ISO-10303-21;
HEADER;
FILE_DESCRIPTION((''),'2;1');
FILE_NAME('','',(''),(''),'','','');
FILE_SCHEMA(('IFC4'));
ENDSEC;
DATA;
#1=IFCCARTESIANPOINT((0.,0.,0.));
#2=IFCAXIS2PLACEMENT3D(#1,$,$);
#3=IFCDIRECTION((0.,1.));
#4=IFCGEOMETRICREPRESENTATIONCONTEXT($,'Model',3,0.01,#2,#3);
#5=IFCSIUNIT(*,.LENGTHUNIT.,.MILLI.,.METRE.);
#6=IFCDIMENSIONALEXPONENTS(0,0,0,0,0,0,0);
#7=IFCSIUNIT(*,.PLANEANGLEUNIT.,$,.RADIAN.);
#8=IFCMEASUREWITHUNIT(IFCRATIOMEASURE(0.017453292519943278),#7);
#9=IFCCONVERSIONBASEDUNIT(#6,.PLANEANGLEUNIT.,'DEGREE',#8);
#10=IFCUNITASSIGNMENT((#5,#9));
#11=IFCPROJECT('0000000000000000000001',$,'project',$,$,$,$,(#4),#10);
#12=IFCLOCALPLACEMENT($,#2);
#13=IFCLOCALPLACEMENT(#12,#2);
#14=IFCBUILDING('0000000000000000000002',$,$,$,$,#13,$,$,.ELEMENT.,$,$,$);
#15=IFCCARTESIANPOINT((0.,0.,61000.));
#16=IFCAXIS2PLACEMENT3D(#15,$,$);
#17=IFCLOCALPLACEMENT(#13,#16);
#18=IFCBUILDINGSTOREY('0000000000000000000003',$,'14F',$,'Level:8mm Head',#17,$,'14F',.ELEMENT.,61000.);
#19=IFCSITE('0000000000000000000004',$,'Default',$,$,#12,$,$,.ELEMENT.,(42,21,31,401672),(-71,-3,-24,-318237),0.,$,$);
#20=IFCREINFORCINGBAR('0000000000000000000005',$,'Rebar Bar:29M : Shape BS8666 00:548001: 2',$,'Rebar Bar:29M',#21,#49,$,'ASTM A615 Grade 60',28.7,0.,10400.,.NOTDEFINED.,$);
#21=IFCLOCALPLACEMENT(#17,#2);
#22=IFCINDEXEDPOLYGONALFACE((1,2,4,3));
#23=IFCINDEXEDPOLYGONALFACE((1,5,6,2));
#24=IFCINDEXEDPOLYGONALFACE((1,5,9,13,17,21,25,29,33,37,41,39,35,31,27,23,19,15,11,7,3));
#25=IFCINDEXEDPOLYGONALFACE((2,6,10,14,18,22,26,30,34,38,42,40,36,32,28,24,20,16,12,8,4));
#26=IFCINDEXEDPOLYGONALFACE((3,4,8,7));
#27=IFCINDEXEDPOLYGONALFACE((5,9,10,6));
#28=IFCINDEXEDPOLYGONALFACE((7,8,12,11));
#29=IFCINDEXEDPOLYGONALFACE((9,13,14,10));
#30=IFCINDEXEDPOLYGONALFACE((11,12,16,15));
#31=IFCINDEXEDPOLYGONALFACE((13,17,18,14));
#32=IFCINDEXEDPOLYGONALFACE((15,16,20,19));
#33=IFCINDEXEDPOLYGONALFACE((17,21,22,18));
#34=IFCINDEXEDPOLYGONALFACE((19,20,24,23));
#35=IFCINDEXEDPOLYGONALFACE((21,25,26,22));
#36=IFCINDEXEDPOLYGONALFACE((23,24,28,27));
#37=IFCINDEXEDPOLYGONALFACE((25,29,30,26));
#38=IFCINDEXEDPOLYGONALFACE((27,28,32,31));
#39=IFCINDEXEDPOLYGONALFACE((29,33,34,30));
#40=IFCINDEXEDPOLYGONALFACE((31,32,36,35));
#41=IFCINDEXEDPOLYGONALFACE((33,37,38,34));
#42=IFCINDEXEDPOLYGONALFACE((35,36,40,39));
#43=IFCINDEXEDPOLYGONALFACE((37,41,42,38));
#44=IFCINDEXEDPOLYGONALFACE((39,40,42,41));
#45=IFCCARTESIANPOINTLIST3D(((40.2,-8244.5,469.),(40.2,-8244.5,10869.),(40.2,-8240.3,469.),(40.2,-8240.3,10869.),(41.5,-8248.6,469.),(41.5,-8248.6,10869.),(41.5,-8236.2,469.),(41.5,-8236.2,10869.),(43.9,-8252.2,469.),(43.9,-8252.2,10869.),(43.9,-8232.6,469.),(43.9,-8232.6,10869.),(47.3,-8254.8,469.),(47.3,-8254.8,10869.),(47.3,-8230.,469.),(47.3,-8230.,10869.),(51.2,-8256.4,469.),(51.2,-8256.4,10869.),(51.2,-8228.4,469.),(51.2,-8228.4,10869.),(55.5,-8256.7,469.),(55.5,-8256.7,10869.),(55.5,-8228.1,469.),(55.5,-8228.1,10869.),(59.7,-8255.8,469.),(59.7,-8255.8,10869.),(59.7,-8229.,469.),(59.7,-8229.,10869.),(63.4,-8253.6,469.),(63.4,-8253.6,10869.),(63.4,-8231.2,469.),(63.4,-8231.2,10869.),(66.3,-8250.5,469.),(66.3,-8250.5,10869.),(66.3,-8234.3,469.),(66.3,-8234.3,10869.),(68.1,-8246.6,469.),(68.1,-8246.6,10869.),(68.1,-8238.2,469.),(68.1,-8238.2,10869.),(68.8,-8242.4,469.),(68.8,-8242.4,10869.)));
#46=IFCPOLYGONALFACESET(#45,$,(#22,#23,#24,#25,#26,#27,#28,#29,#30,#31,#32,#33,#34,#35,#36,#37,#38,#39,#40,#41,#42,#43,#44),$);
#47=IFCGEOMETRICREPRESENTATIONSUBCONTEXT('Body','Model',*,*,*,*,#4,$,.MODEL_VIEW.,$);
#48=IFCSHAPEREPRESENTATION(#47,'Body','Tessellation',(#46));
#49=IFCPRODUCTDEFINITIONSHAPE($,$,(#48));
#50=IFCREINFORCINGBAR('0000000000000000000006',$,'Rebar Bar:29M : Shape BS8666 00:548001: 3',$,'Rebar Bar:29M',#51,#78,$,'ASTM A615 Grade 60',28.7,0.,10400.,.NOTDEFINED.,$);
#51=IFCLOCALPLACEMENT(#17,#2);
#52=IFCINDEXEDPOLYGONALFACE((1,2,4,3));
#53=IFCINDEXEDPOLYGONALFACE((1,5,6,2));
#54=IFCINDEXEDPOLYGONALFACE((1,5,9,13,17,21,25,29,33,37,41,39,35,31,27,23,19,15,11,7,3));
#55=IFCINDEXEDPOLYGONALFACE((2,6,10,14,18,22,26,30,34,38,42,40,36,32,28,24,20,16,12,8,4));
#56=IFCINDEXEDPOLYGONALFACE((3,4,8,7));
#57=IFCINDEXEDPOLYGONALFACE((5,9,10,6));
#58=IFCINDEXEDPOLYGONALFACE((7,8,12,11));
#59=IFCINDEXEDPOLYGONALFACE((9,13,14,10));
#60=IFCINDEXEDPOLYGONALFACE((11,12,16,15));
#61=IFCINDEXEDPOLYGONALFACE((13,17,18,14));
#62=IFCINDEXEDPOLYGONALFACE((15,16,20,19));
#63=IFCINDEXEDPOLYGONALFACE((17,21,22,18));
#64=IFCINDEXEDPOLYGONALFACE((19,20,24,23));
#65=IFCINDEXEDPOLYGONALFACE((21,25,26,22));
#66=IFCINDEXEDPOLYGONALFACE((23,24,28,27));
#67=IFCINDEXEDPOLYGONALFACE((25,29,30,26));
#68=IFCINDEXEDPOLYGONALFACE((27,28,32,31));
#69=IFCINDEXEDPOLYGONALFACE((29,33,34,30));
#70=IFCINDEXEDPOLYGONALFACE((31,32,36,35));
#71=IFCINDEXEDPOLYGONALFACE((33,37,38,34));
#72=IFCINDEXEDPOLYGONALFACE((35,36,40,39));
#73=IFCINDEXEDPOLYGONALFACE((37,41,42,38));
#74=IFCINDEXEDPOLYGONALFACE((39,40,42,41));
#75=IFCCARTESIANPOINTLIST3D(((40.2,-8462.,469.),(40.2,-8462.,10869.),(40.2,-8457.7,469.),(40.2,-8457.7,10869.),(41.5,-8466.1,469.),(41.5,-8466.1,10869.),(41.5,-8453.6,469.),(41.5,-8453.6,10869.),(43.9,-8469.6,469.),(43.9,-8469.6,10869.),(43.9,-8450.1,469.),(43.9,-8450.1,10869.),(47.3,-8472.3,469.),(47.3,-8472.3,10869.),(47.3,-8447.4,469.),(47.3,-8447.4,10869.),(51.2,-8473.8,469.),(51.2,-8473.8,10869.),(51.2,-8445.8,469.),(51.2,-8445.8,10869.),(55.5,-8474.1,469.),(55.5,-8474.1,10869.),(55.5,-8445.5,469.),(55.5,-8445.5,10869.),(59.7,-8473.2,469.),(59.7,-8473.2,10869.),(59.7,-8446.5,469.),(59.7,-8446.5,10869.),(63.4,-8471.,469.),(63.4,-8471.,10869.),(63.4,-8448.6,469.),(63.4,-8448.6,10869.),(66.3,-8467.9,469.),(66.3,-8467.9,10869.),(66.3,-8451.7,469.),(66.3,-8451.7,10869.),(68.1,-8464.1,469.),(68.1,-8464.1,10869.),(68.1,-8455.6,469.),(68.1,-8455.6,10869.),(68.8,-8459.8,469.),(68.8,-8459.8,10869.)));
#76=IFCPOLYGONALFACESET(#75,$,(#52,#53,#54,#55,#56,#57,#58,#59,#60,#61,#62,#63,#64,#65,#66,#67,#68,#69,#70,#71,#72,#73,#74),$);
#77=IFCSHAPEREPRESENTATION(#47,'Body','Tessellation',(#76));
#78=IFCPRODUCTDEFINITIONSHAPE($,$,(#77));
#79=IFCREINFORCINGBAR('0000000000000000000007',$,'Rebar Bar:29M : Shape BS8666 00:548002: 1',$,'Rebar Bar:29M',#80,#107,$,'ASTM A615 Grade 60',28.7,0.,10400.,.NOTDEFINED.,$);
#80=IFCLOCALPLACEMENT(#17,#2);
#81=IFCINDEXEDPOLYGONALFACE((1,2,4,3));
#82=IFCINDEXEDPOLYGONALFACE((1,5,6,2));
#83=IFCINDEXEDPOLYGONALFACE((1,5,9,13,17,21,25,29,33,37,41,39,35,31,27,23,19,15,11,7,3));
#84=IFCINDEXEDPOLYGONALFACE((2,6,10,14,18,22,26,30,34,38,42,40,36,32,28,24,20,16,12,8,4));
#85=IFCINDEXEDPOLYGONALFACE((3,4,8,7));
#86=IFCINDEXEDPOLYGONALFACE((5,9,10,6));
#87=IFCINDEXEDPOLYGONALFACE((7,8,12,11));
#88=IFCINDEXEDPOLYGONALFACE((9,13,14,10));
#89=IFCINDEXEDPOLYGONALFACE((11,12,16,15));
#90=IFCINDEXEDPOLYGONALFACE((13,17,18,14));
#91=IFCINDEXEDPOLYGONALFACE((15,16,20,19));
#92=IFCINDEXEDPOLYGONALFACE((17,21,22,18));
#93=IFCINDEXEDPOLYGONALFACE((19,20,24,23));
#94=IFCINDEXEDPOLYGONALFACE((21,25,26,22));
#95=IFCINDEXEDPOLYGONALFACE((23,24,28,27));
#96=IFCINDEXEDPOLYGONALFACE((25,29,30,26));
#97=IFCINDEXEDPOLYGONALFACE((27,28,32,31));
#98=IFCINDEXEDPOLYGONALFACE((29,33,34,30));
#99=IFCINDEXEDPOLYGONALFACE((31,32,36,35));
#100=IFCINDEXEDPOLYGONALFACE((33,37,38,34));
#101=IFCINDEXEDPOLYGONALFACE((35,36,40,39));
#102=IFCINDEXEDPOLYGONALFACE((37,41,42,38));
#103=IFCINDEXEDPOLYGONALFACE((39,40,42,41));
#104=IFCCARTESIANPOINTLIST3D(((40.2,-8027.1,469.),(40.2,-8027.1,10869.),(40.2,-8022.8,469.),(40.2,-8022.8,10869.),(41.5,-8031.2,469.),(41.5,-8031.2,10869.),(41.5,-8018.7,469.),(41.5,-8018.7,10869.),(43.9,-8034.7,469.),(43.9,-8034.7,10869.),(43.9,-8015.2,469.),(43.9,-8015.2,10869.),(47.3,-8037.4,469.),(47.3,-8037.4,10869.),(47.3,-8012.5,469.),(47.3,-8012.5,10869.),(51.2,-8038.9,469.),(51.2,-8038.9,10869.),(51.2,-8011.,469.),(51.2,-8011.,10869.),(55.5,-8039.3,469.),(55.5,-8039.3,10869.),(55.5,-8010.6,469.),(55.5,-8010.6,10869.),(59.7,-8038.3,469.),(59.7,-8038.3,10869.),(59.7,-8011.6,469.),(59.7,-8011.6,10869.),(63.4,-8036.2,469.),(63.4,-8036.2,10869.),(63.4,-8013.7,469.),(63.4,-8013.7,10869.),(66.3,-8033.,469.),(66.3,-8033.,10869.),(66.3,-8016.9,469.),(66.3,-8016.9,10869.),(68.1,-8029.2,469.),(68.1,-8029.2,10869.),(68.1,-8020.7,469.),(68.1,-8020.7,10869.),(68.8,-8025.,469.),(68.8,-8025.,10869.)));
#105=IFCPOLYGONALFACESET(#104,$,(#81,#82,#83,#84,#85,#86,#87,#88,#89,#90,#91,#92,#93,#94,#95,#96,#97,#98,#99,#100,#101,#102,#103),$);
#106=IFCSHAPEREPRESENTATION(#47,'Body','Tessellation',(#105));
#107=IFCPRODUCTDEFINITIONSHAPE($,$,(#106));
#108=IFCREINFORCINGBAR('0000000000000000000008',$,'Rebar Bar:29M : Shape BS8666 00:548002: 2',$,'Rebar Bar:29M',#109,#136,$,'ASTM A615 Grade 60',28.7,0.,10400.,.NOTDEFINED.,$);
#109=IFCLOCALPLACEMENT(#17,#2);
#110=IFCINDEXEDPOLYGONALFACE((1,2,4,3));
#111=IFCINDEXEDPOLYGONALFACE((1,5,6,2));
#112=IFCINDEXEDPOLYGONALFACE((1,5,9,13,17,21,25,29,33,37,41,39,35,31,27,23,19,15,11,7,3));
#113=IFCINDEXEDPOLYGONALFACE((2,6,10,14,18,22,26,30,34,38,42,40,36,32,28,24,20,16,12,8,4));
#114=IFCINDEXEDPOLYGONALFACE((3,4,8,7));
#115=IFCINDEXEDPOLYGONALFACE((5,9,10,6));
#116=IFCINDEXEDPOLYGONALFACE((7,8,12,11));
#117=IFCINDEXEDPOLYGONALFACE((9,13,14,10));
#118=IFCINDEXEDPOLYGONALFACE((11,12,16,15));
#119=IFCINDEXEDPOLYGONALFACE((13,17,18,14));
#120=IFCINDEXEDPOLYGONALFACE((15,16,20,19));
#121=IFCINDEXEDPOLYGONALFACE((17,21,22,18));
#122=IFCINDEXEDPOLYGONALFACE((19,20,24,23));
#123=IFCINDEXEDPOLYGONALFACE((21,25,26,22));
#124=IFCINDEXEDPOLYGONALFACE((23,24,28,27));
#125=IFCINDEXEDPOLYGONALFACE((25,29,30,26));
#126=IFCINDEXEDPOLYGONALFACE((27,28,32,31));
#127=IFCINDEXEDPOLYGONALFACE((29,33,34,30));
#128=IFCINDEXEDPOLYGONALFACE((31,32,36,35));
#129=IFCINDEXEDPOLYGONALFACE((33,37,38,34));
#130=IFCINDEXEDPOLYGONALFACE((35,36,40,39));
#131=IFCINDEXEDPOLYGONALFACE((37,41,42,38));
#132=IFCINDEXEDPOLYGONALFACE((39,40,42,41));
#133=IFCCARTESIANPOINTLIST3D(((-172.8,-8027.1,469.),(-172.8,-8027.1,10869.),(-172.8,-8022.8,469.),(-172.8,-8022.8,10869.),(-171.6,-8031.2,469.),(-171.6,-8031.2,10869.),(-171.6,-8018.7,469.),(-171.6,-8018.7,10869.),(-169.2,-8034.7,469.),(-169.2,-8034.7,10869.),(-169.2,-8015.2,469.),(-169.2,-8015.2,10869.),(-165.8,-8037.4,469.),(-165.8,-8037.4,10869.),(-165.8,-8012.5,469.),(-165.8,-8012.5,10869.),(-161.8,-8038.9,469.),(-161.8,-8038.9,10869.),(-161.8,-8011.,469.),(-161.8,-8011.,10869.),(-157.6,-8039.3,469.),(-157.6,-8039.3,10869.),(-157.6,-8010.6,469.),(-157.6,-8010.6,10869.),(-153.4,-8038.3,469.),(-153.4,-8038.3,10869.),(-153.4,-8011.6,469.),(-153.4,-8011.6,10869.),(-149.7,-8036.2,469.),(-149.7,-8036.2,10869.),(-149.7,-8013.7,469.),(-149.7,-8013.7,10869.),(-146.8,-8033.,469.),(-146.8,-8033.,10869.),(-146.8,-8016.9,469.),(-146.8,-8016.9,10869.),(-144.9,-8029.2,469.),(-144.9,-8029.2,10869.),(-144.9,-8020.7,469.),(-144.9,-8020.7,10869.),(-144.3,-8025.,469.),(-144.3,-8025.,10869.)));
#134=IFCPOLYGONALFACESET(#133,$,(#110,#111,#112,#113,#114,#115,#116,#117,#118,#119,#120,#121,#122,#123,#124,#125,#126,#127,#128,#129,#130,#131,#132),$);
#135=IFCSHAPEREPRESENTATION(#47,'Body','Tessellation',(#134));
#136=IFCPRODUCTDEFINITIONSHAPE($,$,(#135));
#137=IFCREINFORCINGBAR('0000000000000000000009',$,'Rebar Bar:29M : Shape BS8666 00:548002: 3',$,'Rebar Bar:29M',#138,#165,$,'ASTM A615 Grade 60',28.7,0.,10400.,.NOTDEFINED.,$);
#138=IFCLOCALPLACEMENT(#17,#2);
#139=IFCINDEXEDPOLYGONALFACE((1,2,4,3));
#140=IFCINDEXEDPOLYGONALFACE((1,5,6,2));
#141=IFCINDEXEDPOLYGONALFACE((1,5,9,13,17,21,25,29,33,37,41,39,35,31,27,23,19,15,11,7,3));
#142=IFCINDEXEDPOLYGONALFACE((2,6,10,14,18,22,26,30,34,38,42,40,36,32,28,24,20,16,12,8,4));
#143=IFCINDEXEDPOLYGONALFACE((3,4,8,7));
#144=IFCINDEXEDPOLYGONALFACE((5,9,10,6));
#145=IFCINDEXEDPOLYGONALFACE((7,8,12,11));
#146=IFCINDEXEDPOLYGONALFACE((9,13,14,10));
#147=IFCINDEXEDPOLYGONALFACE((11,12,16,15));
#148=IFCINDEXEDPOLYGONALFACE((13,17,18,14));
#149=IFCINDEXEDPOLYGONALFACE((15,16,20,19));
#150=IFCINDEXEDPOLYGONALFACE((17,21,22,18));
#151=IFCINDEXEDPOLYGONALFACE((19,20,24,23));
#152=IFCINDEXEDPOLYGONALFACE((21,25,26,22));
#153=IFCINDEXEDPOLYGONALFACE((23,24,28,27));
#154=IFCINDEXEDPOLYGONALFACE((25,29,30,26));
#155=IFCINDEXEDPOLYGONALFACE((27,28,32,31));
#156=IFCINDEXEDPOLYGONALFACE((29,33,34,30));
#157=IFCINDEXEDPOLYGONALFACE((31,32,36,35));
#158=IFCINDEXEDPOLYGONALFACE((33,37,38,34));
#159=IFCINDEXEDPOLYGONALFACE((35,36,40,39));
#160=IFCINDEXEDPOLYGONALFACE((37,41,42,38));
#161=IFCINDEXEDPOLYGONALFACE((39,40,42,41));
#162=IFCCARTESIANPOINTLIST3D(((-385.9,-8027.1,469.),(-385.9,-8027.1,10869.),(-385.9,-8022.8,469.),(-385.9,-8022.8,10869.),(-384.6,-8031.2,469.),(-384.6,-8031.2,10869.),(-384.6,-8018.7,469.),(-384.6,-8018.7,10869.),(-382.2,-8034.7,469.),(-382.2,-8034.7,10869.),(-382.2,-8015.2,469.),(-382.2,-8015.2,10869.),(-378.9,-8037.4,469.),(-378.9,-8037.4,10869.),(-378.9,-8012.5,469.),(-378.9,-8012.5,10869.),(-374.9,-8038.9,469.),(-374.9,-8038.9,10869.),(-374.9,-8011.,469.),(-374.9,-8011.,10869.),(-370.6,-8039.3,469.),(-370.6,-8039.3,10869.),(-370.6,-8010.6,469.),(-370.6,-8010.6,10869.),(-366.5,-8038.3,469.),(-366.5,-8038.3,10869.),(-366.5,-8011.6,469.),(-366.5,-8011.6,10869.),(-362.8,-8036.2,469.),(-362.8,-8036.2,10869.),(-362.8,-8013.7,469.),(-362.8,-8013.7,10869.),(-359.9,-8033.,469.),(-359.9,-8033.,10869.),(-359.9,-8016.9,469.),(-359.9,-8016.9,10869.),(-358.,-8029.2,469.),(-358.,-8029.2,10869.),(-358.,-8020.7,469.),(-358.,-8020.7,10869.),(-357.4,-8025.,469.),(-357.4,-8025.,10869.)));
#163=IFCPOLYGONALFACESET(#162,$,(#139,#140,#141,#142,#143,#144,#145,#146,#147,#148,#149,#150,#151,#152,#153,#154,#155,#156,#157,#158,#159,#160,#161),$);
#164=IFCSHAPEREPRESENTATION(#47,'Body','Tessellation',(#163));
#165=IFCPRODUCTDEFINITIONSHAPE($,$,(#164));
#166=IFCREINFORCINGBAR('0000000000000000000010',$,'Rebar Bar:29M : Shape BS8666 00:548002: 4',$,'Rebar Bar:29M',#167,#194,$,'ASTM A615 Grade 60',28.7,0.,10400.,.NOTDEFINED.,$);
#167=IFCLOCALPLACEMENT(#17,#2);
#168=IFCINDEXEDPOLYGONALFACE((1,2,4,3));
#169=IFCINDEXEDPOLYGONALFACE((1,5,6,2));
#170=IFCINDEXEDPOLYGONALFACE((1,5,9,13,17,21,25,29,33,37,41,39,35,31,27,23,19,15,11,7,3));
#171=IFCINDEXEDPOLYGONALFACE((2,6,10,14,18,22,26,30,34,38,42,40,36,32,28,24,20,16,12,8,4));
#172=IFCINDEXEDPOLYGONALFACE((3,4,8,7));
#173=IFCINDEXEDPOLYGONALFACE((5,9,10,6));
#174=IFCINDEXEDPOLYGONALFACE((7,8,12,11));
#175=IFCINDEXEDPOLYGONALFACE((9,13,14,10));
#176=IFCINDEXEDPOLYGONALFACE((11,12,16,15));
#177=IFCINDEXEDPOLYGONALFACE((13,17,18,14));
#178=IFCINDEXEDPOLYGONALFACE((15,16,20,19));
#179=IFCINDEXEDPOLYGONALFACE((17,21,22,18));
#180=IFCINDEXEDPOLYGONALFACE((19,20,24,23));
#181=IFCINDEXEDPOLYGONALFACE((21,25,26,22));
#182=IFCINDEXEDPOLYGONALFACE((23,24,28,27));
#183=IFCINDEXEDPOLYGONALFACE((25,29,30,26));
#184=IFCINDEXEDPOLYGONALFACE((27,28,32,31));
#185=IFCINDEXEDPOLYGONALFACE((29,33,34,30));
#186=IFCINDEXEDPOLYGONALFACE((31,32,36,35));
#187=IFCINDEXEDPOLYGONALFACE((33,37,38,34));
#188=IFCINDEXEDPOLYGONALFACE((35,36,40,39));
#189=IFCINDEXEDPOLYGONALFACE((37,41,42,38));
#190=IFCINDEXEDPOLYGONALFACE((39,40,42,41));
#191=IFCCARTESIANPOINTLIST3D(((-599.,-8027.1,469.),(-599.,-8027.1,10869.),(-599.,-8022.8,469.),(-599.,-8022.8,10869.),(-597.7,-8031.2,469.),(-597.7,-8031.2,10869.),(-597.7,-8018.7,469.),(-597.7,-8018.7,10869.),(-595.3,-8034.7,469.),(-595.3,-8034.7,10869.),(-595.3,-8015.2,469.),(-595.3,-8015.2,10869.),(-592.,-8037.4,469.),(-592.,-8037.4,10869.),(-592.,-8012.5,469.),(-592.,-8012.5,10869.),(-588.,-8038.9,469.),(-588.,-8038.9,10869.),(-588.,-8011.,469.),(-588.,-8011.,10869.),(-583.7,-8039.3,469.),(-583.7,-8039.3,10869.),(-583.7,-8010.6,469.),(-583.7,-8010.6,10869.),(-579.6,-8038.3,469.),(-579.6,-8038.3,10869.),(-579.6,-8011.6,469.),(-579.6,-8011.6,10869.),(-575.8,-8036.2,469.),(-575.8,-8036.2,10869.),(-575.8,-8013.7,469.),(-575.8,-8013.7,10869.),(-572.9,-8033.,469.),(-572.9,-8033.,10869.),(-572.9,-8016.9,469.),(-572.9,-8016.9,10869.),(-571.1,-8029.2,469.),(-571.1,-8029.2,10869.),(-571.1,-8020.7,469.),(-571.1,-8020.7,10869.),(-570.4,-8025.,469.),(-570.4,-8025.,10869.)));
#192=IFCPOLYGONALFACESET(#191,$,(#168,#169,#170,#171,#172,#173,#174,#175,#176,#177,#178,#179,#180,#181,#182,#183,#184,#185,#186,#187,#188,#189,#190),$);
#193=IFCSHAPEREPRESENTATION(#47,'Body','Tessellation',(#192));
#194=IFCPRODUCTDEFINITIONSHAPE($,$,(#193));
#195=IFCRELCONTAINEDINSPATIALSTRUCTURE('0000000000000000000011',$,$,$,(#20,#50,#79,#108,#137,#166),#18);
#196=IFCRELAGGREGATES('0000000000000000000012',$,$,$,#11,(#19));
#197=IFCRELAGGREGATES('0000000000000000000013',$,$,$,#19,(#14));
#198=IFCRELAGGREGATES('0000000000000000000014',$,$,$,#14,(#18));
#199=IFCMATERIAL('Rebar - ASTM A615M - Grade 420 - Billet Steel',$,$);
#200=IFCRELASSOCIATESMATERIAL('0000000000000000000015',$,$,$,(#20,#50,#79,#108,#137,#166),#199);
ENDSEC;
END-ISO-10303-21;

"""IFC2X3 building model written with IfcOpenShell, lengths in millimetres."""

from ifc_helpers import new_model, entity, si_unit, converted_unit, direction, frame, origin, place, context, subcontext, project, spatial, material, element, save


model = new_model("IFC2X3")

# Units and contexts
model_context = context("Model", 3, precision=0.01, world=origin(), true_north=direction((0.0, 1.0)))
body_context = subcontext(model_context, "Body", "Model", "MODEL_VIEW")
ifc_project = project(units=[si_unit("LENGTHUNIT", "METRE", prefix="MILLI"), converted_unit("PLANEANGLEUNIT", "DEGREE", entity("IfcRatioMeasure", 0.017453292519943278), si_unit("PLANEANGLEUNIT", "RADIAN"), dimensions=[0, 0, 0, 0, 0, 0, 0])], contexts=[model_context])

# Site, building, storey
site_placement = place(None, origin())
site = spatial("IfcSite", under=ifc_project, at=site_placement, Name="Default", CompositionType="ELEMENT", RefLatitude=(42, 21, 31, 401672), RefLongitude=(-71, -3, -24, -318237), RefElevation=0.0)
building_placement = place(site_placement, origin())
building = spatial("IfcBuilding", under=site, at=building_placement, CompositionType="ELEMENT")
storey_placement = place(building_placement, frame((0.0, 0.0, 61000.0)))
storey = spatial("IfcBuildingStorey", under=building, at=storey_placement, Name="14F", ObjectType="Level:8mm Head", LongName="14F", CompositionType="ELEMENT", Elevation=61000.0)

# Reinforcing bars
ifc_material_1 = material(Name="Rebar - ASTM A615M - Grade 420 - Billet Steel")
reinforcing_bar_1_placement = place(storey_placement, origin())
element("IfcReinforcingBar", 1, at=reinforcing_bar_1_placement, inside=storey, material=ifc_material_1, Name="Rebar Bar:29M : Shape BS8666 00:548001: 2", SteelGrade="ASTM A615 Grade 60", ObjectType="Rebar Bar:29M", BarLength=10400.0, BarRole="NOTDEFINED", CrossSectionArea=0.0, NominalDiameter=28.7, context=body_context, shape_type="AdvancedSweptSolid", body=[
    entity("IfcSweptDiskSolid", entity("IfcCompositeCurve", [entity("IfcCompositeCurveSegment", "CONTINUOUS", True, entity("IfcPolyline", [entity("IfcCartesianPoint", [54.4, -8242.4, 469.0]), entity("IfcCartesianPoint", [54.4, -8242.4, 10869.0])]))], False), 14.3, None, 0.0, 1.0),
])
reinforcing_bar_2_placement = place(storey_placement, origin())
element("IfcReinforcingBar", 2, at=reinforcing_bar_2_placement, inside=storey, material=ifc_material_1, Name="Rebar Bar:29M : Shape BS8666 00:548001: 3", SteelGrade="ASTM A615 Grade 60", ObjectType="Rebar Bar:29M", BarLength=10400.0, BarRole="NOTDEFINED", CrossSectionArea=0.0, NominalDiameter=28.7, context=body_context, shape_type="AdvancedSweptSolid", body=[
    entity("IfcSweptDiskSolid", entity("IfcCompositeCurve", [entity("IfcCompositeCurveSegment", "CONTINUOUS", True, entity("IfcPolyline", [entity("IfcCartesianPoint", [54.4, -8459.8, 469.0]), entity("IfcCartesianPoint", [54.4, -8459.8, 10869.0])]))], False), 14.3, None, 0.0, 1.0),
])
reinforcing_bar_3_placement = place(storey_placement, origin())
element("IfcReinforcingBar", 3, at=reinforcing_bar_3_placement, inside=storey, material=ifc_material_1, Name="Rebar Bar:29M : Shape BS8666 00:548002: 1", SteelGrade="ASTM A615 Grade 60", ObjectType="Rebar Bar:29M", BarLength=10400.0, BarRole="NOTDEFINED", CrossSectionArea=0.0, NominalDiameter=28.7, context=body_context, shape_type="AdvancedSweptSolid", body=[
    entity("IfcSweptDiskSolid", entity("IfcCompositeCurve", [entity("IfcCompositeCurveSegment", "CONTINUOUS", True, entity("IfcPolyline", [entity("IfcCartesianPoint", [54.4, -8025.0, 469.0]), entity("IfcCartesianPoint", [54.4, -8025.0, 10869.0])]))], False), 14.3, None, 0.0, 1.0),
])
reinforcing_bar_4_placement = place(storey_placement, origin())
element("IfcReinforcingBar", 4, at=reinforcing_bar_4_placement, inside=storey, material=ifc_material_1, Name="Rebar Bar:29M : Shape BS8666 00:548002: 2", SteelGrade="ASTM A615 Grade 60", ObjectType="Rebar Bar:29M", BarLength=10400.0, BarRole="NOTDEFINED", CrossSectionArea=0.0, NominalDiameter=28.7, context=body_context, shape_type="AdvancedSweptSolid", body=[
    entity("IfcSweptDiskSolid", entity("IfcCompositeCurve", [entity("IfcCompositeCurveSegment", "CONTINUOUS", True, entity("IfcPolyline", [entity("IfcCartesianPoint", [-158.6, -8025.0, 469.0]), entity("IfcCartesianPoint", [-158.6, -8025.0, 10869.0])]))], False), 14.3, None, 0.0, 1.0),
])
reinforcing_bar_5_placement = place(storey_placement, origin())
element("IfcReinforcingBar", 5, at=reinforcing_bar_5_placement, inside=storey, material=ifc_material_1, Name="Rebar Bar:29M : Shape BS8666 00:548002: 3", SteelGrade="ASTM A615 Grade 60", ObjectType="Rebar Bar:29M", BarLength=10400.0, BarRole="NOTDEFINED", CrossSectionArea=0.0, NominalDiameter=28.7, context=body_context, shape_type="AdvancedSweptSolid", body=[
    entity("IfcSweptDiskSolid", entity("IfcCompositeCurve", [entity("IfcCompositeCurveSegment", "CONTINUOUS", True, entity("IfcPolyline", [entity("IfcCartesianPoint", [-371.7, -8025.0, 469.0]), entity("IfcCartesianPoint", [-371.7, -8025.0, 10869.0])]))], False), 14.3, None, 0.0, 1.0),
])
reinforcing_bar_6_placement = place(storey_placement, origin())
element("IfcReinforcingBar", 6, at=reinforcing_bar_6_placement, inside=storey, material=ifc_material_1, Name="Rebar Bar:29M : Shape BS8666 00:548002: 4", SteelGrade="ASTM A615 Grade 60", ObjectType="Rebar Bar:29M", BarLength=10400.0, BarRole="NOTDEFINED", CrossSectionArea=0.0, NominalDiameter=28.7, context=body_context, shape_type="AdvancedSweptSolid", body=[
    entity("IfcSweptDiskSolid", entity("IfcCompositeCurve", [entity("IfcCompositeCurveSegment", "CONTINUOUS", True, entity("IfcPolyline", [entity("IfcCartesianPoint", [-584.8, -8025.0, 469.0]), entity("IfcCartesianPoint", [-584.8, -8025.0, 10869.0])]))], False), 14.3, None, 0.0, 1.0),
])

save(model, "model.ifc")
